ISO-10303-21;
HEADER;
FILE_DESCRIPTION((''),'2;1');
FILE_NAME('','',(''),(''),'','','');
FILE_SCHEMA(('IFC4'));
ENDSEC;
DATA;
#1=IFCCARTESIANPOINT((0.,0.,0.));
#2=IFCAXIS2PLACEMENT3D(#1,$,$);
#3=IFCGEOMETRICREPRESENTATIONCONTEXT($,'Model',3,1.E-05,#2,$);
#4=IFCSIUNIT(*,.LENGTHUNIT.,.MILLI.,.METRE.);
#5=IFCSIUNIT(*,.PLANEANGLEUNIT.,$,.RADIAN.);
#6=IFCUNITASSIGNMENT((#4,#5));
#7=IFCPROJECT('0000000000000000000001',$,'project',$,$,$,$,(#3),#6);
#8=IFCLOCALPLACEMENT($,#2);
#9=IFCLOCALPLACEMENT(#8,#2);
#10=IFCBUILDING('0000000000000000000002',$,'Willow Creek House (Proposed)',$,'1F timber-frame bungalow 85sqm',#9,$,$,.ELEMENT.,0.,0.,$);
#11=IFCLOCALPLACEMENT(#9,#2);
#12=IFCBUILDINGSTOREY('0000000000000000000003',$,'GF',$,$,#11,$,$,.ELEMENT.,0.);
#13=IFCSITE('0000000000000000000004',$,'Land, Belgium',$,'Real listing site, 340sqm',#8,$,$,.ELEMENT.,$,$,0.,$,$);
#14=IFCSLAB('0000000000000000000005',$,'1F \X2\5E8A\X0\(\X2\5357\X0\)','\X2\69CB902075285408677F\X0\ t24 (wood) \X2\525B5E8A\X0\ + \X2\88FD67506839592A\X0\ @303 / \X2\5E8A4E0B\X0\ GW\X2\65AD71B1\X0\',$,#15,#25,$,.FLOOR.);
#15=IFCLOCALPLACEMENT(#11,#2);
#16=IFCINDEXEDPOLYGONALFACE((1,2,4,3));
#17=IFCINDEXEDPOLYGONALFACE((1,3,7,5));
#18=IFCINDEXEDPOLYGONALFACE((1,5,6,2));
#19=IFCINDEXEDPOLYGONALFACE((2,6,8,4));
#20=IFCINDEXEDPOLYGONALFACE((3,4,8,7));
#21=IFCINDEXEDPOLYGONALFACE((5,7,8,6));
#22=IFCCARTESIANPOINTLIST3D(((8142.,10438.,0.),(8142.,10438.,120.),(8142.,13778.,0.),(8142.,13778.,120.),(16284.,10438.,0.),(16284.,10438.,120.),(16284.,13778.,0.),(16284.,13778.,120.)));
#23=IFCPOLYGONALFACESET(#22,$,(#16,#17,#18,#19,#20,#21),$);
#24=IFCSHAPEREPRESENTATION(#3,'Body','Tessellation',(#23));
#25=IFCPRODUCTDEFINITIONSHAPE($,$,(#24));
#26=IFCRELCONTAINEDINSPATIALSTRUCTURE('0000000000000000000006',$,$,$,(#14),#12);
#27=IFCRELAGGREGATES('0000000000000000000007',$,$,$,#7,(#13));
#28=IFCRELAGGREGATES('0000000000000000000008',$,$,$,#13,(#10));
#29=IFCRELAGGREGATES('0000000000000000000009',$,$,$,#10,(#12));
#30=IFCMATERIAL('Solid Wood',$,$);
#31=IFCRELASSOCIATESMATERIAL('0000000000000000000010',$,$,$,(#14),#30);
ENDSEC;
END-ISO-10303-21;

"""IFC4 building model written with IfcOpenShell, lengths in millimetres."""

from ifc_helpers import new_model, si_unit, frame, frame_2d, origin, place, context, project, spatial, rectangle, extrude, material, element, save


model = new_model("IFC4")

# Units and contexts
model_context = context("Model", 3, precision=1e-05, world=origin())
ifc_project = project(units=[si_unit("LENGTHUNIT", "METRE", prefix="MILLI"), si_unit("PLANEANGLEUNIT", "RADIAN")], contexts=[model_context])

# Site, building, storey
site_placement = place(None, origin())
site = spatial("IfcSite", under=ifc_project, at=site_placement, Name="Land, Belgium", ObjectType="Real listing site, 340sqm", CompositionType="ELEMENT", RefElevation=0.0)
building_placement = place(site_placement, origin())
building = spatial("IfcBuilding", under=site, at=building_placement, Name="Willow Creek House (Proposed)", ObjectType="1F timber-frame bungalow 85sqm", CompositionType="ELEMENT", ElevationOfRefHeight=0.0, ElevationOfTerrain=0.0)
storey_placement = place(building_placement, origin())
storey = spatial("IfcBuildingStorey", under=building, at=storey_placement, Name="GF", CompositionType="ELEMENT", Elevation=0.0)

# Shared definitions
ifc_material_1 = material(Name="Solid Wood")

# Slab
slab_1_placement = place(storey_placement, frame((4071.0, 5219.0, 0.0)))
element("IfcSlab", 1, at=slab_1_placement, inside=storey, material=ifc_material_1, Name="1F 床(南)", Description="構造用合板 t24 (wood) 剛床 + 製材根太 @303 / 床下 GW断熱", PredefinedType="FLOOR", context=model_context, shape_type="SweptSolid", body=[
    extrude(rectangle(XDim=8142.0, YDim=3340.0, at=frame_2d((4071.0, 1670.0))), frame((4071.0, 5219.0, 0.0)), (0.0, 0.0, 1.0), 120.0),
])

save(model, "model.ifc")
